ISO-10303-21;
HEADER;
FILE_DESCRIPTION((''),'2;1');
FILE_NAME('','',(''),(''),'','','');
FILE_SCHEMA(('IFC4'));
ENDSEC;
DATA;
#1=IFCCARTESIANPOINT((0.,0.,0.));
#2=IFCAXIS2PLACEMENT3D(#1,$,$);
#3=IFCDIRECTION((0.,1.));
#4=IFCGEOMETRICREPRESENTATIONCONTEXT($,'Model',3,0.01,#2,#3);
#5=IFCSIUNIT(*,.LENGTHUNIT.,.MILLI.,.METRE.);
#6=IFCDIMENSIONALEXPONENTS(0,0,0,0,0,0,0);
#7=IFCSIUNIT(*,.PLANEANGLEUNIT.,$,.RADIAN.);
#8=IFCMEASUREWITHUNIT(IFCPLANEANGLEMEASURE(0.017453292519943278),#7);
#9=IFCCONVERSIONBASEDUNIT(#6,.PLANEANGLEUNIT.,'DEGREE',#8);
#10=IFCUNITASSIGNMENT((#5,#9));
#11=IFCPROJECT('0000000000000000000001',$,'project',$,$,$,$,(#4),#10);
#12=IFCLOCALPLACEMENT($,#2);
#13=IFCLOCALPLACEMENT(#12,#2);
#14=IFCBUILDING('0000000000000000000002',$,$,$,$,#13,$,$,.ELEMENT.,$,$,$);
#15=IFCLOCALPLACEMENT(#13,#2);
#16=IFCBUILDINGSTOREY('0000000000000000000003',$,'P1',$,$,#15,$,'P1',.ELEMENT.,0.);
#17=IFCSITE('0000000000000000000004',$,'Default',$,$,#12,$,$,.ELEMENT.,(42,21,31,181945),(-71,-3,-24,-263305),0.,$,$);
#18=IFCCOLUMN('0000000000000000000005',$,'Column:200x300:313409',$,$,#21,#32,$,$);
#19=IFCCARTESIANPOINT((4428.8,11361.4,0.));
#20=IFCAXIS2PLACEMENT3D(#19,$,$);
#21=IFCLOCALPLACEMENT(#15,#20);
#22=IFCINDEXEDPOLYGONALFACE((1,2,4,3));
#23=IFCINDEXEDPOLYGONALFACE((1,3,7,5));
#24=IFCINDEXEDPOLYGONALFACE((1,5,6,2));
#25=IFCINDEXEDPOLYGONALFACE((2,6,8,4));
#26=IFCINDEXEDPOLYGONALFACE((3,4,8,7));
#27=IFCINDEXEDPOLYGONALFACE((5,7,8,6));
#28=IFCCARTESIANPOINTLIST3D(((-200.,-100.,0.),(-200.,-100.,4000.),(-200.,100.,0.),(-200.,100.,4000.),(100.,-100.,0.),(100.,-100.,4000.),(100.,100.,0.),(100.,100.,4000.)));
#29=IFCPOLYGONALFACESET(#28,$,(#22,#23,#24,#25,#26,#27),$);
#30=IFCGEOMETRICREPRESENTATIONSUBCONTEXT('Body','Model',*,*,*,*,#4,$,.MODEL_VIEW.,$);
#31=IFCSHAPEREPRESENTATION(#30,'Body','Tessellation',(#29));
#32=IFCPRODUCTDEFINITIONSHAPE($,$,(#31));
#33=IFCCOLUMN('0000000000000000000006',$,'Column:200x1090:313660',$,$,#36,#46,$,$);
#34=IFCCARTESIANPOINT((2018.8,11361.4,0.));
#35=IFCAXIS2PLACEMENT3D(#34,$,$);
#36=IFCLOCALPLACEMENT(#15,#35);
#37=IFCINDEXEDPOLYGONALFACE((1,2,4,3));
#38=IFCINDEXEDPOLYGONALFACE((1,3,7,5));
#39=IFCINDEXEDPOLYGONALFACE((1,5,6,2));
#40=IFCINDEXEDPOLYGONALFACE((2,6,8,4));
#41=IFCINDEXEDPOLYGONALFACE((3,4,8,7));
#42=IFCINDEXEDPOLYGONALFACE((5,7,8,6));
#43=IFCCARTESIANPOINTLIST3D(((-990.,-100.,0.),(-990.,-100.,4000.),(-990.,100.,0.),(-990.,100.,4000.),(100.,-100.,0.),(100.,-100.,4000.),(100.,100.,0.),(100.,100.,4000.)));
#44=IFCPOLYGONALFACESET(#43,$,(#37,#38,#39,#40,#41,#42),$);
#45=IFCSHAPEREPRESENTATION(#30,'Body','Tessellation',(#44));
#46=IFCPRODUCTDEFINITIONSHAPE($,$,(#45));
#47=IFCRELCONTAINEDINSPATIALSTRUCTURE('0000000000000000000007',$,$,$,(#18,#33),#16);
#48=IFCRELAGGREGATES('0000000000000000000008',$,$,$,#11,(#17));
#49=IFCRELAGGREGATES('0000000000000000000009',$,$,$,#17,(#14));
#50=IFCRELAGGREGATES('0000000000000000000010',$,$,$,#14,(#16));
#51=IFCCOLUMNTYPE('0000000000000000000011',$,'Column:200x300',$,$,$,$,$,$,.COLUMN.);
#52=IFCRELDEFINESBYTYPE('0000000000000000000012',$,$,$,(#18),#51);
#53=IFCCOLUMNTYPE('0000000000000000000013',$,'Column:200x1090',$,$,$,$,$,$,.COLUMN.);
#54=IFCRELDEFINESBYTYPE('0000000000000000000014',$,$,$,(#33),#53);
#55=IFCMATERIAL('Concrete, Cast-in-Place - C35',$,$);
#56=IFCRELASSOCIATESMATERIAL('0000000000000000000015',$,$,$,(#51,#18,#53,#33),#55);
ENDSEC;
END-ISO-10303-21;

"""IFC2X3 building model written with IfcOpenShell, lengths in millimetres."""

from ifc_helpers import new_model, entity, si_unit, converted_unit, direction, frame, origin, origin_2d_with_axis, place, context, subcontext, project, spatial, rectangle, extrude, source, transform, mapped, material, type_object, type_shapes, element, save


model = new_model("IFC2X3")

# Units and contexts
model_context = context("Model", 3, precision=0.01, world=origin(), true_north=direction((0.0, 1.0)))
body_context = subcontext(model_context, "Body", "Model", "MODEL_VIEW")
ifc_project = project(units=[si_unit("LENGTHUNIT", "METRE", prefix="MILLI"), converted_unit("PLANEANGLEUNIT", "DEGREE", entity("IfcPlaneAngleMeasure", 0.017453292519943278), si_unit("PLANEANGLEUNIT", "RADIAN"), dimensions=[0, 0, 0, 0, 0, 0, 0])], contexts=[model_context])

# Site, building, storey
site_placement = place(None, origin())
site = spatial("IfcSite", under=ifc_project, at=site_placement, Name="Default", CompositionType="ELEMENT", RefLatitude=(42, 21, 31, 181945), RefLongitude=(-71, -3, -24, -263305), RefElevation=0.0)
building_placement = place(site_placement, origin())
building = spatial("IfcBuilding", under=site, at=building_placement, CompositionType="ELEMENT")
storey_placement = place(building_placement, origin())
storey = spatial("IfcBuildingStorey", under=building, at=storey_placement, Name="P1", LongName="P1", CompositionType="ELEMENT", Elevation=0.0)

# Columns
ifc_material_1 = material(Name="Concrete, Cast-in-Place - C35")
column_type_1 = type_object("IfcColumnType", Name="Column:200x300", PredefinedType="COLUMN", material=ifc_material_1)
shared_shape_1 = source(origin(), body_context, "Body", "SweptSolid", [
    extrude(rectangle(XDim=300.0, YDim=200.0, at=origin_2d_with_axis()), frame((-50.0, 0.0, 0.0), z_axis=(0.0, 0.0, 1.0), x_axis=(-1.0, 0.0, 0.0)), (0.0, 0.0, 1.0), 4000.0),
])
type_shapes(column_type_1, [shared_shape_1])
column_1_placement = place(storey_placement, frame((4428.8, 11361.4, 0.0)))
element("IfcColumn", 1, at=column_1_placement, inside=storey, type_object=column_type_1, material=ifc_material_1, Name="Column:200x300:313409", context=body_context, shape_type="MappedRepresentation", body=[
    mapped(shared_shape_1, transform((0.0, 0.0, 0.0), scale=1.0)),
])
column_type_2 = type_object("IfcColumnType", Name="Column:200x1090", PredefinedType="COLUMN", material=ifc_material_1)
shared_shape_2 = source(origin(), body_context, "Body", "SweptSolid", [
    extrude(rectangle(XDim=1090.0, YDim=200.0, at=origin_2d_with_axis()), frame((-445.0, 0.0, 0.0), z_axis=(0.0, 0.0, 1.0), x_axis=(-1.0, 0.0, 0.0)), (0.0, 0.0, 1.0), 4000.0),
])
type_shapes(column_type_2, [shared_shape_2])
column_2_placement = place(storey_placement, frame((2018.8, 11361.4, 0.0)))
element("IfcColumn", 2, at=column_2_placement, inside=storey, type_object=column_type_2, material=ifc_material_1, Name="Column:200x1090:313660", context=body_context, shape_type="MappedRepresentation", body=[
    mapped(shared_shape_2, transform((0.0, 0.0, 0.0), scale=1.0)),
])

save(model, "model.ifc")
